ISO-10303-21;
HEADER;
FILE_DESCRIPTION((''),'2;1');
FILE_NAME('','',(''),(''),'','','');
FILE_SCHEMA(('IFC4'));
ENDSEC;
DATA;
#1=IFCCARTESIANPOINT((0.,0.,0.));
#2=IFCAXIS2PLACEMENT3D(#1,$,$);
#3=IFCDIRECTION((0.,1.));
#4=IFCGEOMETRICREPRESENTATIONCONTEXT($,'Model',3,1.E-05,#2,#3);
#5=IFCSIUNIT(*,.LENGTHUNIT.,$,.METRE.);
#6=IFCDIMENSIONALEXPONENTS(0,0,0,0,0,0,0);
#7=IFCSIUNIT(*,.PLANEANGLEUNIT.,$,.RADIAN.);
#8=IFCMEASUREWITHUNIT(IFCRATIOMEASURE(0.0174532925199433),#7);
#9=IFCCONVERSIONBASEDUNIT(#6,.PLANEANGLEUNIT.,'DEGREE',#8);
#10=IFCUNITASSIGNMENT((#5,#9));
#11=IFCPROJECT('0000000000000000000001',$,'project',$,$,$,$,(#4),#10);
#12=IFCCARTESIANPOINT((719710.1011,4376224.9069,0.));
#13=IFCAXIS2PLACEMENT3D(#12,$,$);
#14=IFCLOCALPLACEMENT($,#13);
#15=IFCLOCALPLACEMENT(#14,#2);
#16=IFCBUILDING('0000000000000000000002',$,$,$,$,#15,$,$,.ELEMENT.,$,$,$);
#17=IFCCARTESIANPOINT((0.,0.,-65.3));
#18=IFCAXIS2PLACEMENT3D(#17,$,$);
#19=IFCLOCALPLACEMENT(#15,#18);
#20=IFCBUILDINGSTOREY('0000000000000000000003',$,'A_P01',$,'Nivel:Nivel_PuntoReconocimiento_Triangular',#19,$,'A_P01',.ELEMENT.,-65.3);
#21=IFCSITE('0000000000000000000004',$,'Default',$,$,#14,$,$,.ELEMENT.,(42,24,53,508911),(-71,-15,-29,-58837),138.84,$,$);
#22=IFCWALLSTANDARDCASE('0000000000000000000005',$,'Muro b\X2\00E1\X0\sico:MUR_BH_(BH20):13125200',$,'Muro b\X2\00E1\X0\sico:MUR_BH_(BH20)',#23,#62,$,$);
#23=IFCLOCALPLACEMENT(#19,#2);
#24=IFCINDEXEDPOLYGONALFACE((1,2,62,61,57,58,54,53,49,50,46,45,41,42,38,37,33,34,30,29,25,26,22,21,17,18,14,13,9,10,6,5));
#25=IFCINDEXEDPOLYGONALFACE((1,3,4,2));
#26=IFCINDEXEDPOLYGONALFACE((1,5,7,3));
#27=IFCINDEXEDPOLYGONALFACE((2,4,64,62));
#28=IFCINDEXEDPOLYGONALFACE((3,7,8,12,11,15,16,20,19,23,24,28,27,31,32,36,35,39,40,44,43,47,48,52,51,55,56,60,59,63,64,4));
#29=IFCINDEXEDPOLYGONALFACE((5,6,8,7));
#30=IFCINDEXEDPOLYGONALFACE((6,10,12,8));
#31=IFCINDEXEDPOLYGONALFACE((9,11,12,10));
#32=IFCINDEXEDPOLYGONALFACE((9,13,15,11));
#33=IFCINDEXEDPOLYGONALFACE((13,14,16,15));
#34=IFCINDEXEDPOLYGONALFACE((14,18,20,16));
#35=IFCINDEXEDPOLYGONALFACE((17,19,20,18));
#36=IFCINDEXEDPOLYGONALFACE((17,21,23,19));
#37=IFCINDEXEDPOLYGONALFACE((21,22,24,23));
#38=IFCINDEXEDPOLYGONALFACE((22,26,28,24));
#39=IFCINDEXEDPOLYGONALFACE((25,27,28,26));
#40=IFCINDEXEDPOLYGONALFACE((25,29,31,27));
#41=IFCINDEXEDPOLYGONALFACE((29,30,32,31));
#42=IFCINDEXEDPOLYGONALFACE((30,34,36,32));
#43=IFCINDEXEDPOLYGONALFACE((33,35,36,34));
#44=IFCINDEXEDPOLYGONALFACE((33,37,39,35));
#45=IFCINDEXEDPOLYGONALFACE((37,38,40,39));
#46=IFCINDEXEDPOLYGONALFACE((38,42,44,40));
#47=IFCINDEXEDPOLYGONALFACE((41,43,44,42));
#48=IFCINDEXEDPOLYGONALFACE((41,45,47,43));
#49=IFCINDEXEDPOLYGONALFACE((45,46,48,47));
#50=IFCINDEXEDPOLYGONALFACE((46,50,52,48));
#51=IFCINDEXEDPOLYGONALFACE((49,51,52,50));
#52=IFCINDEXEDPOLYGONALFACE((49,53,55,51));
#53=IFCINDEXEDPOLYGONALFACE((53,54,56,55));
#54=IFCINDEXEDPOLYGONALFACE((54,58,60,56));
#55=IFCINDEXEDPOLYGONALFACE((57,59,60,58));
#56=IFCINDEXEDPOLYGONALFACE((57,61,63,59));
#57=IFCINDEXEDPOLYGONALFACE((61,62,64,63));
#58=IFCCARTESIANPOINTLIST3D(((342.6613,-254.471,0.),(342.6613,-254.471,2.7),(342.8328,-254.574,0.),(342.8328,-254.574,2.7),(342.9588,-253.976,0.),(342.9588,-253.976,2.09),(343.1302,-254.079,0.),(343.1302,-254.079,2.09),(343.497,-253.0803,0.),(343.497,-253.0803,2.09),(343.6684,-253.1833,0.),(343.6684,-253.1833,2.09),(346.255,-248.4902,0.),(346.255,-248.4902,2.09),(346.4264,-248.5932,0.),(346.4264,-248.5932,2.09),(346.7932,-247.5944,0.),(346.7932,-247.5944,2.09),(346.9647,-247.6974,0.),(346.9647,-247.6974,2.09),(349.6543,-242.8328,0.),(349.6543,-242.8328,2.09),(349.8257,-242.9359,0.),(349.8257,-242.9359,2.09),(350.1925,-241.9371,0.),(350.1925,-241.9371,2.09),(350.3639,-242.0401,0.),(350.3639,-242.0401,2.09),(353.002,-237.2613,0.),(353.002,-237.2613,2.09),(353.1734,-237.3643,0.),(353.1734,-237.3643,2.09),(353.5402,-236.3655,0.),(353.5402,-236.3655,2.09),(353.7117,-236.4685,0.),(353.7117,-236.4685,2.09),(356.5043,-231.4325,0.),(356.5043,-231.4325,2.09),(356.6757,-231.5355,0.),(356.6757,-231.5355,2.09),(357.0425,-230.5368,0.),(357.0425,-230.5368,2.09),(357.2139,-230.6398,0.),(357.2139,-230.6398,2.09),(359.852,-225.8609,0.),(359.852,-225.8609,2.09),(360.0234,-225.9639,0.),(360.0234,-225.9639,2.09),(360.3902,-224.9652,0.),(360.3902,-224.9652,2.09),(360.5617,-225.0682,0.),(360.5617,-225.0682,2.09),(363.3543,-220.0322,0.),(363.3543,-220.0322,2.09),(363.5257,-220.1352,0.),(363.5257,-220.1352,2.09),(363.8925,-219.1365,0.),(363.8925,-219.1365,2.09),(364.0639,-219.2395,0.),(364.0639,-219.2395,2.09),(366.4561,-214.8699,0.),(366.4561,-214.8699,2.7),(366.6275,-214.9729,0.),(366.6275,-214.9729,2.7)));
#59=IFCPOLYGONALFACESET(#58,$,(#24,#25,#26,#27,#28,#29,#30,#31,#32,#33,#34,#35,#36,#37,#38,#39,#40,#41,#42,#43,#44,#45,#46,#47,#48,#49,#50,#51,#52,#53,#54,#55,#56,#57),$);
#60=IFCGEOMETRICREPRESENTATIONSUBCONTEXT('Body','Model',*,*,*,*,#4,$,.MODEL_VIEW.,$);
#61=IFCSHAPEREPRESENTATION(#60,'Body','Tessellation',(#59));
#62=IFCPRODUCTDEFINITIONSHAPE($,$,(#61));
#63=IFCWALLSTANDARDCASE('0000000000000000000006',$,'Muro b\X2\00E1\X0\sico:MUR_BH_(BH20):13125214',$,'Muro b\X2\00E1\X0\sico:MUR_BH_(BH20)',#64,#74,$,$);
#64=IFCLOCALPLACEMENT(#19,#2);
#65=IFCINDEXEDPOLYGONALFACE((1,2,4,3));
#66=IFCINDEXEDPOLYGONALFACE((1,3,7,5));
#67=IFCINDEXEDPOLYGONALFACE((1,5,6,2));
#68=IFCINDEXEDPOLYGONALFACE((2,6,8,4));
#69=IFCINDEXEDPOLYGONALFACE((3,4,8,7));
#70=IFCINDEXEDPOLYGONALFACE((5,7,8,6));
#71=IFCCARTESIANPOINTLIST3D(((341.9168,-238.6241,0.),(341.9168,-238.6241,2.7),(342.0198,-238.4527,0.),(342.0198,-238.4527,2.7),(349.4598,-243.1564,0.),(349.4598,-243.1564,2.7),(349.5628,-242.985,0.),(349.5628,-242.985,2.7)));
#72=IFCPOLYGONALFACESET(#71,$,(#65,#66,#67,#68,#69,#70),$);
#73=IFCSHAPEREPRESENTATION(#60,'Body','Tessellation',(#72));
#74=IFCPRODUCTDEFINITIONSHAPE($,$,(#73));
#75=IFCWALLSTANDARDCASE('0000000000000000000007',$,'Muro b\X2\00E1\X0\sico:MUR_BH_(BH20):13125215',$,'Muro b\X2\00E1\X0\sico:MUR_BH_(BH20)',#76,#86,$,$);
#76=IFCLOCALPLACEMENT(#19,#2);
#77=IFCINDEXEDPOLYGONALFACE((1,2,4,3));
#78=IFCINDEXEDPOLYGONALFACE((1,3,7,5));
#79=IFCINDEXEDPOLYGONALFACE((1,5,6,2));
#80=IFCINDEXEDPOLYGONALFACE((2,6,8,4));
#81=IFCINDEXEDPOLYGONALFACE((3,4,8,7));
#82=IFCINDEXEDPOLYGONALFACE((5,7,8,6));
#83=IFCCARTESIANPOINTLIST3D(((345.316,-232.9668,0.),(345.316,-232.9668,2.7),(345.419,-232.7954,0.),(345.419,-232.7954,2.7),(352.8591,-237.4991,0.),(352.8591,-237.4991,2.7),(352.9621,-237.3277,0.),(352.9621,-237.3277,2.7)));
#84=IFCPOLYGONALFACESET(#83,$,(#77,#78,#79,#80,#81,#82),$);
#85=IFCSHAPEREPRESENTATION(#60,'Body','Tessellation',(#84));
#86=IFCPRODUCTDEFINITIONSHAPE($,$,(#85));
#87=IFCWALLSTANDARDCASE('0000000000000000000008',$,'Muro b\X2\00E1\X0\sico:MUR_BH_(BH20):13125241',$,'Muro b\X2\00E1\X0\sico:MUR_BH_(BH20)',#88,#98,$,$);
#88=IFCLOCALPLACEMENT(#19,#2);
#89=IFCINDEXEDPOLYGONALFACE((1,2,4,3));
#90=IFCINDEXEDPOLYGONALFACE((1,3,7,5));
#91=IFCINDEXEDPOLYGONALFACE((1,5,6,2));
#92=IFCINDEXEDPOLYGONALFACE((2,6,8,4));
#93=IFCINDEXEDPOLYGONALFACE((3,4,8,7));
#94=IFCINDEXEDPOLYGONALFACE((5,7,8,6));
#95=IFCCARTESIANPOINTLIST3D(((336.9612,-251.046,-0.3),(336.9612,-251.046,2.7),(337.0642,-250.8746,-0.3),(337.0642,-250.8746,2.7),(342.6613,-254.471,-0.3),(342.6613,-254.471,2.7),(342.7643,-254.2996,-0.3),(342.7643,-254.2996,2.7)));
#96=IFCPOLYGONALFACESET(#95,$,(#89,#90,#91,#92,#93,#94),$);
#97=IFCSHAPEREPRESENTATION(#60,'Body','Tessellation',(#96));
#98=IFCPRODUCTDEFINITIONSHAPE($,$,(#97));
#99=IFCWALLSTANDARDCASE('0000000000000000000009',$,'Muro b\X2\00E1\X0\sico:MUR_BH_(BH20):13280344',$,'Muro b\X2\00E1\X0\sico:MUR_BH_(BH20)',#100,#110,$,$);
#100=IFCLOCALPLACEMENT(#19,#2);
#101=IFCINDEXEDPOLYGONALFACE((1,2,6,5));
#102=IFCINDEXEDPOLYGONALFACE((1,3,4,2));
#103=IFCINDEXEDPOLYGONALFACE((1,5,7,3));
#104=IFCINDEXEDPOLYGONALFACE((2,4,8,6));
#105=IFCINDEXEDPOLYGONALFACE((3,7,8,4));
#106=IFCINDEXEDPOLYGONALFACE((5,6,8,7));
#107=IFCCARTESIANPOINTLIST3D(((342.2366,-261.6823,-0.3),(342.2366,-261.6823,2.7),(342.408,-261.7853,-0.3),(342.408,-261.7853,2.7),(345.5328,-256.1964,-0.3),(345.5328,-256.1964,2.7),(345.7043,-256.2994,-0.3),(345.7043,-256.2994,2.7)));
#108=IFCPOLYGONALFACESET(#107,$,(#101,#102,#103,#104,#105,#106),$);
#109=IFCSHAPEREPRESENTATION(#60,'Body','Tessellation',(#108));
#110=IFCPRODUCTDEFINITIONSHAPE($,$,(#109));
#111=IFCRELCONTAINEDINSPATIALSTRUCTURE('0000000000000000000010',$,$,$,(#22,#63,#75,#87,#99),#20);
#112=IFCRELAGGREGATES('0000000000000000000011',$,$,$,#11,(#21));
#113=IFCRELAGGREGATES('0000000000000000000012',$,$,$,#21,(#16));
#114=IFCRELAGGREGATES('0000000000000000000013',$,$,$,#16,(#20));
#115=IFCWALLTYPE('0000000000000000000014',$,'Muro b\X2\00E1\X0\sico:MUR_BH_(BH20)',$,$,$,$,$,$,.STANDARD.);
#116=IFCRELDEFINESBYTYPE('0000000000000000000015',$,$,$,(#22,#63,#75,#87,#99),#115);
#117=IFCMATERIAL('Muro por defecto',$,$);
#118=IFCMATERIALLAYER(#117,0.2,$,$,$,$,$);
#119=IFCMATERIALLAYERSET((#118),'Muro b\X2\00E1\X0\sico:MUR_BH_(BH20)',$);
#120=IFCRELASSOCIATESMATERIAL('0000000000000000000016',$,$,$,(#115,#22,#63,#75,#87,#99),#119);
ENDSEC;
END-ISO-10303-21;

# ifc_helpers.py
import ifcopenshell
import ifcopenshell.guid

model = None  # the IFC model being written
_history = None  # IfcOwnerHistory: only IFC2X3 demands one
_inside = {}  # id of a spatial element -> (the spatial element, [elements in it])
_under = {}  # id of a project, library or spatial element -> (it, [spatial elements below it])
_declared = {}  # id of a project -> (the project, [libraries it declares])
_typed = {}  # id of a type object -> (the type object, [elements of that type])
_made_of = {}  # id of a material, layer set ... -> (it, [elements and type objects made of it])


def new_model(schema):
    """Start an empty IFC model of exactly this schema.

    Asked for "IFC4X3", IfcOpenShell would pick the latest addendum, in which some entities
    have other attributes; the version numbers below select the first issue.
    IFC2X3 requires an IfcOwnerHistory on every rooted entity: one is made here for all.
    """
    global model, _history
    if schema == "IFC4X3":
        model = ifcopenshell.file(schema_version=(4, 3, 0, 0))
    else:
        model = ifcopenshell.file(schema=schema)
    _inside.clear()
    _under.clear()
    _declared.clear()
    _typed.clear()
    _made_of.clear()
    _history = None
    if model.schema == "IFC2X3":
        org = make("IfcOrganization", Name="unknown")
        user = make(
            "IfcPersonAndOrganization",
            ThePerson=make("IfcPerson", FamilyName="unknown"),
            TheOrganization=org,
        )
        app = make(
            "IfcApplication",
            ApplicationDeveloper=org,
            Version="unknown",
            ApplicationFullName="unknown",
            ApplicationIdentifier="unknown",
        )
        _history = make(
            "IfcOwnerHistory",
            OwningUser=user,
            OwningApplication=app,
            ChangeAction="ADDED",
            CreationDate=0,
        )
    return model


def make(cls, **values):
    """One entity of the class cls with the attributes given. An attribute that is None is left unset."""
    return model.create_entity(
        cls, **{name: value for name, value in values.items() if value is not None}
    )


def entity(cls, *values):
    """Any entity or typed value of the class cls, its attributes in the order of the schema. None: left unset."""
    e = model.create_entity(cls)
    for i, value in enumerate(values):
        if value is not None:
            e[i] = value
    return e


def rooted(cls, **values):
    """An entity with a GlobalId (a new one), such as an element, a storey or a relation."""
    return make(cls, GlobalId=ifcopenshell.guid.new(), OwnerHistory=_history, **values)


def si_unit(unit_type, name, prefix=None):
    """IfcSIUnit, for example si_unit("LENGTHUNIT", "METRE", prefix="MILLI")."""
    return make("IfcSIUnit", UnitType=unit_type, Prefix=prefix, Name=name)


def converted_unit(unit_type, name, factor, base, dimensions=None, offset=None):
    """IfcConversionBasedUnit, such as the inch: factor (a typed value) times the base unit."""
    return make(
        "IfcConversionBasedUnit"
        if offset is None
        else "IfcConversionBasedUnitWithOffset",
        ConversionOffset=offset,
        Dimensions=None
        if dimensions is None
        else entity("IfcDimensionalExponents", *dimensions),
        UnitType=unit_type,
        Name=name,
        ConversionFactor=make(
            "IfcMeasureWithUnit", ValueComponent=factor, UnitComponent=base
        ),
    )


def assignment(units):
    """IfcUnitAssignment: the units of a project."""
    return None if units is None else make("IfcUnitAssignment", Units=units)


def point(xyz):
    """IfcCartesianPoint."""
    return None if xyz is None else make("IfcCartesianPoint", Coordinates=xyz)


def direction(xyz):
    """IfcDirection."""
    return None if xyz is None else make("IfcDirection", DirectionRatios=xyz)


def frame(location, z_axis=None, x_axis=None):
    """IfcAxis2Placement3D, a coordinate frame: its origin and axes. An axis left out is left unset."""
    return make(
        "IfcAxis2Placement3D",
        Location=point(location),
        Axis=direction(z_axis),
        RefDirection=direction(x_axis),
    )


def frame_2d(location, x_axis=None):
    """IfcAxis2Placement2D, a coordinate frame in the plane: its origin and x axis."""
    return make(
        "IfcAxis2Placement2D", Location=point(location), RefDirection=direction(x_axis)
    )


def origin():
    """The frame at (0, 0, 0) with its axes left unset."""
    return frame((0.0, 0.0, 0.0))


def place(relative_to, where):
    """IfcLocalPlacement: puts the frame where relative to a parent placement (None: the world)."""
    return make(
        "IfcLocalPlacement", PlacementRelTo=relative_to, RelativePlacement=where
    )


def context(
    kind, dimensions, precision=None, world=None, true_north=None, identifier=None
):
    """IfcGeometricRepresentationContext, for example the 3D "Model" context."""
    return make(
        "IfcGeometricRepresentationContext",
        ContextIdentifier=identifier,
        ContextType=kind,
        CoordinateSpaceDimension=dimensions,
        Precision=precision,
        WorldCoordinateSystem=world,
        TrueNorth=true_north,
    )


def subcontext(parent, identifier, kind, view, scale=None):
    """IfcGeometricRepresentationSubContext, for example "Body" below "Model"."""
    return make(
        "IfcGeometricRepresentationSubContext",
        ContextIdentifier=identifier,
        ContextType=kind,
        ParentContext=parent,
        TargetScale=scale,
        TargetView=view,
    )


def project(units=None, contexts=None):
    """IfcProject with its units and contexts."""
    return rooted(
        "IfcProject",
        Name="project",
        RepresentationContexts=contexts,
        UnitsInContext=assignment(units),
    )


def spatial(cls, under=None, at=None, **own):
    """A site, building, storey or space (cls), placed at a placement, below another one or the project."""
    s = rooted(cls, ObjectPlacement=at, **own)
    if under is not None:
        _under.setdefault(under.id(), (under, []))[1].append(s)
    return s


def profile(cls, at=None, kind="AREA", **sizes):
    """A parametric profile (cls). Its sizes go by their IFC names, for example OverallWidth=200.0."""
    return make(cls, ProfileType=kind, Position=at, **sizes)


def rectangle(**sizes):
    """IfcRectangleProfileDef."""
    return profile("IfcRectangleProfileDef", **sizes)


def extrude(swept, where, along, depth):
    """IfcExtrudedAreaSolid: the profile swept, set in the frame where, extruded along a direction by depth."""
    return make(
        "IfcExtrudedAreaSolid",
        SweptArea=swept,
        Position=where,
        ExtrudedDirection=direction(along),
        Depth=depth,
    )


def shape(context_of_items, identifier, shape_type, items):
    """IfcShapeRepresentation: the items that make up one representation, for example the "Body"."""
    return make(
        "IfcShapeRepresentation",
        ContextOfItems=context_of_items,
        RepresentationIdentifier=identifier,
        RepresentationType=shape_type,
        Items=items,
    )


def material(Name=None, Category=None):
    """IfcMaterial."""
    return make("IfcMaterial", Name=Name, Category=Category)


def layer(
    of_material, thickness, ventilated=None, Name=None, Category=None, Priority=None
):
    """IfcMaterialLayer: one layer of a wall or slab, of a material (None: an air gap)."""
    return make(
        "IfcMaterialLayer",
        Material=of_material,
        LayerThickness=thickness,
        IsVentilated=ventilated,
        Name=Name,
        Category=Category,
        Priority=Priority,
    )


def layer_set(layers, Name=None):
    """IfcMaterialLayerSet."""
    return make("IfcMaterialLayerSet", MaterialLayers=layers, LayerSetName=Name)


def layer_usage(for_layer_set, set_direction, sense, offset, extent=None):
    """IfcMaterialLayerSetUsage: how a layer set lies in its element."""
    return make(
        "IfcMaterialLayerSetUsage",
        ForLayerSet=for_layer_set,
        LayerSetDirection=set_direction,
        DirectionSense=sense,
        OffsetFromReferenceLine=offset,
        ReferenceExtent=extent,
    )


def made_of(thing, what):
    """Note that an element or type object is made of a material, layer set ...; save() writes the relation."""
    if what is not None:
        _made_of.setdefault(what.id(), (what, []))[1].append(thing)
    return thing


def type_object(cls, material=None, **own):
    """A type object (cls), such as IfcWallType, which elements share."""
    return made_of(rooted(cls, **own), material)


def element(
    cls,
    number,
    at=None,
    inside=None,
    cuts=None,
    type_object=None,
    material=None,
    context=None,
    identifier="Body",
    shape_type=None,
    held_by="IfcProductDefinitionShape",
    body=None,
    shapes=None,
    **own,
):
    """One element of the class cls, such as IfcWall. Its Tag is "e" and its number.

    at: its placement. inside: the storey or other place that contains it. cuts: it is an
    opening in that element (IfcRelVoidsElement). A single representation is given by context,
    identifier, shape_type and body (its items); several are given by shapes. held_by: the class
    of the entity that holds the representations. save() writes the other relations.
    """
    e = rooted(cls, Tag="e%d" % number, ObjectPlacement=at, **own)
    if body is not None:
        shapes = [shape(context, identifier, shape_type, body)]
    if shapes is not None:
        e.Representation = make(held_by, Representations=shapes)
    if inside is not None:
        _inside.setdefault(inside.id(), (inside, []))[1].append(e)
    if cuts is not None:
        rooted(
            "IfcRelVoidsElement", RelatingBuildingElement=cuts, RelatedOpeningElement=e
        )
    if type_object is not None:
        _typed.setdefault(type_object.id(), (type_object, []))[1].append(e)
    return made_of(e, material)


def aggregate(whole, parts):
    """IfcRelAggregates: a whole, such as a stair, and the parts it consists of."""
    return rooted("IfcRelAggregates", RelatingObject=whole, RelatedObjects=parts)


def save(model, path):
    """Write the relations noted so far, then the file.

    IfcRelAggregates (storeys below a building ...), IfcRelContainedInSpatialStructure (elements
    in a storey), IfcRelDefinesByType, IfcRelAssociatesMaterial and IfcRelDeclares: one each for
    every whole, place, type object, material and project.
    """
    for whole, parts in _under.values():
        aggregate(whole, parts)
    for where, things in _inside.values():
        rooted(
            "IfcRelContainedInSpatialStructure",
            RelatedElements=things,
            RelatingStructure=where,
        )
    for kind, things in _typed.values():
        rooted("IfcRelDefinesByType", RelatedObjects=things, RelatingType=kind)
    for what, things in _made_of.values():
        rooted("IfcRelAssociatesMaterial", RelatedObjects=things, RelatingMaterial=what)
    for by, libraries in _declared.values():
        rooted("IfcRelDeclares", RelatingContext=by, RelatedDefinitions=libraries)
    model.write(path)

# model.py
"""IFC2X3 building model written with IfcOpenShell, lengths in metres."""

from ifc_helpers import new_model, entity, si_unit, converted_unit, direction, frame, frame_2d, origin, place, context, subcontext, project, spatial, rectangle, extrude, material, layer, layer_set, layer_usage, type_object, element, save


model = new_model("IFC2X3")

# Units and contexts
model_context = context("Model", 3, precision=1e-05, world=origin(), true_north=direction((0.0, 1.0)))
body_context = subcontext(model_context, "Body", "Model", "MODEL_VIEW")
ifc_project = project(units=[si_unit("LENGTHUNIT", "METRE"), converted_unit("PLANEANGLEUNIT", "DEGREE", entity("IfcRatioMeasure", 0.0174532925199433), si_unit("PLANEANGLEUNIT", "RADIAN"), dimensions=[0, 0, 0, 0, 0, 0, 0])], contexts=[model_context])

# Site, building, storey
site_placement = place(None, frame((719710.1011, 4376224.9069, 0.0)))
site = spatial("IfcSite", under=ifc_project, at=site_placement, Name="Default", CompositionType="ELEMENT", RefLatitude=(42, 24, 53, 508911), RefLongitude=(-71, -15, -29, -58837), RefElevation=138.84)
building_placement = place(site_placement, origin())
building = spatial("IfcBuilding", under=site, at=building_placement, CompositionType="ELEMENT")
storey_placement = place(building_placement, frame((0.0, 0.0, -65.3)))
storey = spatial("IfcBuildingStorey", under=building, at=storey_placement, Name="A_P01", ObjectType="Nivel:Nivel_PuntoReconocimiento_Triangular", LongName="A_P01", CompositionType="ELEMENT", Elevation=-65.3)

# Wall, openings
ifc_material_1 = material(Name="Muro por defecto")
ifc_layer = layer(ifc_material_1, 0.2)
ifc_layer_set = layer_set([ifc_layer], Name="Muro básico:MUR_BH_(BH20)")
ifc_layer_usage_1 = layer_usage(ifc_layer_set, "AXIS2", "NEGATIVE", 0.1)
wall_type = type_object("IfcWallType", Name="Muro básico:MUR_BH_(BH20)", PredefinedType="STANDARD", material=ifc_layer_set)
wall_1_placement = place(storey_placement, frame((342.747, -254.5225, 0.0), z_axis=(0.0, 0.0, 1.0), x_axis=(0.515038, 0.857167, 0.0)))
wall_1 = element("IfcWallStandardCase", 1, at=wall_1_placement, inside=storey, type_object=wall_type, material=ifc_layer_usage_1, Name="Muro básico:MUR_BH_(BH20):13125200", ObjectType="Muro básico:MUR_BH_(BH20)", context=body_context, shape_type="SweptSolid", body=[
    extrude(rectangle(XDim=46.2, YDim=0.2, at=frame_2d((23.1, 0.0), x_axis=(-1.0, 0.0))), origin(), (0.0, 0.0, 1.0), 2.7),
])
opening_1_placement = place(wall_1_placement, frame((41.6406, 424.8804, 0.0), z_axis=(0.0, 0.0, 1.0), x_axis=(0.515038, -0.857167, 0.0)))
element("IfcOpeningElement", 2, at=opening_1_placement, cuts=wall_1, ObjectType="Opening", context=body_context, shape_type="SweptSolid", body=[
    extrude(rectangle(XDim=2.09, YDim=1.045, at=frame_2d((0.0, 0.0), x_axis=(0.0, 1.0))), frame((363.7948, -219.6873, 1.045), z_axis=(-0.857167, 0.515038, 0.0), x_axis=(0.515038, 0.857167, 0.0)), (0.0, 0.0, 1.0), 0.2),
])
opening_2_placement = place(wall_1_placement, frame((41.6406, 424.8804, 0.0), z_axis=(0.0, 0.0, 1.0), x_axis=(0.515038, -0.857167, 0.0)))
element("IfcOpeningElement", 3, at=opening_2_placement, cuts=wall_1, ObjectType="Opening", context=body_context, shape_type="SweptSolid", body=[
    extrude(rectangle(XDim=2.09, YDim=1.045, at=frame_2d((0.0, 0.0), x_axis=(0.0, 1.0))), frame((360.2926, -225.5161, 1.045), z_axis=(-0.857167, 0.515038, 0.0), x_axis=(0.515038, 0.857167, 0.0)), (0.0, 0.0, 1.0), 0.2),
])
opening_3_placement = place(wall_1_placement, frame((41.6406, 424.8804, 0.0), z_axis=(0.0, 0.0, 1.0), x_axis=(0.515038, -0.857167, 0.0)))
element("IfcOpeningElement", 4, at=opening_3_placement, cuts=wall_1, ObjectType="Opening", context=body_context, shape_type="SweptSolid", body=[
    extrude(rectangle(XDim=2.09, YDim=1.045, at=frame_2d((0.0, 0.0), x_axis=(0.0, 1.0))), frame((356.9448, -231.0877, 1.045), z_axis=(-0.857167, 0.515038, 0.0), x_axis=(0.515038, 0.857167, 0.0)), (0.0, 0.0, 1.0), 0.2),
])
opening_4_placement = place(wall_1_placement, frame((41.6406, 424.8804, 0.0), z_axis=(0.0, 0.0, 1.0), x_axis=(0.515038, -0.857167, 0.0)))
element("IfcOpeningElement", 5, at=opening_4_placement, cuts=wall_1, ObjectType="Opening", context=body_context, shape_type="SweptSolid", body=[
    extrude(rectangle(XDim=2.09, YDim=1.045, at=frame_2d((0.0, 0.0), x_axis=(0.0, 1.0))), frame((353.4425, -236.9164, 1.045), z_axis=(-0.857167, 0.515038, 0.0), x_axis=(0.515038, 0.857167, 0.0)), (0.0, 0.0, 1.0), 0.2),
])
opening_5_placement = place(wall_1_placement, frame((41.6406, 424.8804, 0.0), z_axis=(0.0, 0.0, 1.0), x_axis=(0.515038, -0.857167, 0.0)))
element("IfcOpeningElement", 6, at=opening_5_placement, cuts=wall_1, ObjectType="Opening", context=body_context, shape_type="SweptSolid", body=[
    extrude(rectangle(XDim=2.09, YDim=1.045, at=frame_2d((0.0, 0.0), x_axis=(0.0, 1.0))), frame((350.0948, -242.488, 1.045), z_axis=(-0.857167, 0.515038, 0.0), x_axis=(0.515038, 0.857167, 0.0)), (0.0, 0.0, 1.0), 0.2),
])
opening_6_placement = place(wall_1_placement, frame((41.6406, 424.8804, 0.0), z_axis=(0.0, 0.0, 1.0), x_axis=(0.515038, -0.857167, 0.0)))
element("IfcOpeningElement", 7, at=opening_6_placement, cuts=wall_1, ObjectType="Opening", context=body_context, shape_type="SweptSolid", body=[
    extrude(rectangle(XDim=2.09, YDim=1.045, at=frame_2d((0.0, 0.0), x_axis=(0.0, 1.0))), frame((346.6955, -248.1453, 1.045), z_axis=(-0.857167, 0.515038, 0.0), x_axis=(0.515038, 0.857167, 0.0)), (0.0, 0.0, 1.0), 0.2),
])
opening_7_placement = place(wall_1_placement, frame((41.6406, 424.8804, 0.0), z_axis=(0.0, 0.0, 1.0), x_axis=(0.515038, -0.857167, 0.0)))
element("IfcOpeningElement", 8, at=opening_7_placement, cuts=wall_1, ObjectType="Opening", context=body_context, shape_type="SweptSolid", body=[
    extrude(rectangle(XDim=2.09, YDim=1.045, at=frame_2d((0.0, 0.0), x_axis=(0.0, 1.0))), frame((343.3993, -253.6312, 1.045), z_axis=(-0.857167, 0.515038, 0.0), x_axis=(0.515038, 0.857167, 0.0)), (0.0, 0.0, 1.0), 0.2),
])

# Walls
ifc_layer_usage_2 = layer_usage(ifc_layer_set, "AXIS2", "NEGATIVE", 0.1)
wall_2_placement = place(storey_placement, frame((341.9683, -238.5384, 0.0), z_axis=(0.0, 0.0, 1.0), x_axis=(0.857167, -0.515038, 0.0)))
element("IfcWallStandardCase", 9, at=wall_2_placement, inside=storey, type_object=wall_type, material=ifc_layer_usage_2, Name="Muro básico:MUR_BH_(BH20):13125214", ObjectType="Muro básico:MUR_BH_(BH20)", context=body_context, shape_type="SweptSolid", body=[
    extrude(rectangle(XDim=8.8, YDim=0.2, at=frame_2d((4.4, 0.0), x_axis=(-1.0, 0.0))), origin(), (0.0, 0.0, 1.0), 2.7),
])
ifc_layer_usage_3 = layer_usage(ifc_layer_set, "AXIS2", "NEGATIVE", 0.1)
wall_3_placement = place(storey_placement, frame((345.3675, -232.8811, 0.0), z_axis=(0.0, 0.0, 1.0), x_axis=(0.857167, -0.515038, 0.0)))
element("IfcWallStandardCase", 10, at=wall_3_placement, inside=storey, type_object=wall_type, material=ifc_layer_usage_3, Name="Muro básico:MUR_BH_(BH20):13125215", ObjectType="Muro básico:MUR_BH_(BH20)", context=body_context, shape_type="SweptSolid", body=[
    extrude(rectangle(XDim=8.8, YDim=0.2, at=frame_2d((4.4, 0.0), x_axis=(-1.0, 0.0))), origin(), (0.0, 0.0, 1.0), 2.7),
])

# Wall, opening
ifc_layer_usage_4 = layer_usage(ifc_layer_set, "AXIS2", "NEGATIVE", 0.1)
wall_4_placement = place(storey_placement, frame((342.7128, -254.3853, -0.3), z_axis=(0.0, 0.0, 1.0), x_axis=(-0.857167, 0.515038, 0.0)))
wall_4 = element("IfcWallStandardCase", 11, at=wall_4_placement, inside=storey, type_object=wall_type, material=ifc_layer_usage_4, Name="Muro básico:MUR_BH_(BH20):13125241", ObjectType="Muro básico:MUR_BH_(BH20)", context=body_context, shape_type="SweptSolid", body=[
    extrude(rectangle(XDim=6.65, YDim=0.2, at=frame_2d((3.325, 0.0), x_axis=(-1.0, 0.0))), origin(), (0.0, 0.0, 1.0), 3.0),
])
opening_8_placement = place(wall_4_placement, origin())
element("IfcOpeningElement", 12, at=opening_8_placement, cuts=wall_4, ObjectType="Opening", context=body_context, shape_type="SweptSolid", body=[
    extrude(rectangle(XDim=2.09, YDim=0.2, at=frame_2d((0.0, 0.0), x_axis=(0.0, 1.0))), frame((-0.1, -1.5225, 1.345), z_axis=(0.0, 1.0, 0.0), x_axis=(1.0, 0.0, 0.0)), (0.0, 0.0, 1.0), 1.045),
])

# Wall
ifc_layer_usage_5 = layer_usage(ifc_layer_set, "AXIS2", "NEGATIVE", 0.1)
wall_5_placement = place(storey_placement, frame((345.6186, -256.2479, -0.3), z_axis=(0.0, 0.0, 1.0), x_axis=(-0.515038, -0.857167, 0.0)))
element("IfcWallStandardCase", 13, at=wall_5_placement, inside=storey, type_object=wall_type, material=ifc_layer_usage_5, Name="Muro básico:MUR_BH_(BH20):13280344", ObjectType="Muro básico:MUR_BH_(BH20)", context=body_context, shape_type="SweptSolid", body=[
    extrude(rectangle(XDim=6.4, YDim=0.2, at=frame_2d((3.2, 0.0), x_axis=(-1.0, 0.0))), origin(), (0.0, 0.0, 1.0), 3.0),
])

save(model, "model.ifc")
